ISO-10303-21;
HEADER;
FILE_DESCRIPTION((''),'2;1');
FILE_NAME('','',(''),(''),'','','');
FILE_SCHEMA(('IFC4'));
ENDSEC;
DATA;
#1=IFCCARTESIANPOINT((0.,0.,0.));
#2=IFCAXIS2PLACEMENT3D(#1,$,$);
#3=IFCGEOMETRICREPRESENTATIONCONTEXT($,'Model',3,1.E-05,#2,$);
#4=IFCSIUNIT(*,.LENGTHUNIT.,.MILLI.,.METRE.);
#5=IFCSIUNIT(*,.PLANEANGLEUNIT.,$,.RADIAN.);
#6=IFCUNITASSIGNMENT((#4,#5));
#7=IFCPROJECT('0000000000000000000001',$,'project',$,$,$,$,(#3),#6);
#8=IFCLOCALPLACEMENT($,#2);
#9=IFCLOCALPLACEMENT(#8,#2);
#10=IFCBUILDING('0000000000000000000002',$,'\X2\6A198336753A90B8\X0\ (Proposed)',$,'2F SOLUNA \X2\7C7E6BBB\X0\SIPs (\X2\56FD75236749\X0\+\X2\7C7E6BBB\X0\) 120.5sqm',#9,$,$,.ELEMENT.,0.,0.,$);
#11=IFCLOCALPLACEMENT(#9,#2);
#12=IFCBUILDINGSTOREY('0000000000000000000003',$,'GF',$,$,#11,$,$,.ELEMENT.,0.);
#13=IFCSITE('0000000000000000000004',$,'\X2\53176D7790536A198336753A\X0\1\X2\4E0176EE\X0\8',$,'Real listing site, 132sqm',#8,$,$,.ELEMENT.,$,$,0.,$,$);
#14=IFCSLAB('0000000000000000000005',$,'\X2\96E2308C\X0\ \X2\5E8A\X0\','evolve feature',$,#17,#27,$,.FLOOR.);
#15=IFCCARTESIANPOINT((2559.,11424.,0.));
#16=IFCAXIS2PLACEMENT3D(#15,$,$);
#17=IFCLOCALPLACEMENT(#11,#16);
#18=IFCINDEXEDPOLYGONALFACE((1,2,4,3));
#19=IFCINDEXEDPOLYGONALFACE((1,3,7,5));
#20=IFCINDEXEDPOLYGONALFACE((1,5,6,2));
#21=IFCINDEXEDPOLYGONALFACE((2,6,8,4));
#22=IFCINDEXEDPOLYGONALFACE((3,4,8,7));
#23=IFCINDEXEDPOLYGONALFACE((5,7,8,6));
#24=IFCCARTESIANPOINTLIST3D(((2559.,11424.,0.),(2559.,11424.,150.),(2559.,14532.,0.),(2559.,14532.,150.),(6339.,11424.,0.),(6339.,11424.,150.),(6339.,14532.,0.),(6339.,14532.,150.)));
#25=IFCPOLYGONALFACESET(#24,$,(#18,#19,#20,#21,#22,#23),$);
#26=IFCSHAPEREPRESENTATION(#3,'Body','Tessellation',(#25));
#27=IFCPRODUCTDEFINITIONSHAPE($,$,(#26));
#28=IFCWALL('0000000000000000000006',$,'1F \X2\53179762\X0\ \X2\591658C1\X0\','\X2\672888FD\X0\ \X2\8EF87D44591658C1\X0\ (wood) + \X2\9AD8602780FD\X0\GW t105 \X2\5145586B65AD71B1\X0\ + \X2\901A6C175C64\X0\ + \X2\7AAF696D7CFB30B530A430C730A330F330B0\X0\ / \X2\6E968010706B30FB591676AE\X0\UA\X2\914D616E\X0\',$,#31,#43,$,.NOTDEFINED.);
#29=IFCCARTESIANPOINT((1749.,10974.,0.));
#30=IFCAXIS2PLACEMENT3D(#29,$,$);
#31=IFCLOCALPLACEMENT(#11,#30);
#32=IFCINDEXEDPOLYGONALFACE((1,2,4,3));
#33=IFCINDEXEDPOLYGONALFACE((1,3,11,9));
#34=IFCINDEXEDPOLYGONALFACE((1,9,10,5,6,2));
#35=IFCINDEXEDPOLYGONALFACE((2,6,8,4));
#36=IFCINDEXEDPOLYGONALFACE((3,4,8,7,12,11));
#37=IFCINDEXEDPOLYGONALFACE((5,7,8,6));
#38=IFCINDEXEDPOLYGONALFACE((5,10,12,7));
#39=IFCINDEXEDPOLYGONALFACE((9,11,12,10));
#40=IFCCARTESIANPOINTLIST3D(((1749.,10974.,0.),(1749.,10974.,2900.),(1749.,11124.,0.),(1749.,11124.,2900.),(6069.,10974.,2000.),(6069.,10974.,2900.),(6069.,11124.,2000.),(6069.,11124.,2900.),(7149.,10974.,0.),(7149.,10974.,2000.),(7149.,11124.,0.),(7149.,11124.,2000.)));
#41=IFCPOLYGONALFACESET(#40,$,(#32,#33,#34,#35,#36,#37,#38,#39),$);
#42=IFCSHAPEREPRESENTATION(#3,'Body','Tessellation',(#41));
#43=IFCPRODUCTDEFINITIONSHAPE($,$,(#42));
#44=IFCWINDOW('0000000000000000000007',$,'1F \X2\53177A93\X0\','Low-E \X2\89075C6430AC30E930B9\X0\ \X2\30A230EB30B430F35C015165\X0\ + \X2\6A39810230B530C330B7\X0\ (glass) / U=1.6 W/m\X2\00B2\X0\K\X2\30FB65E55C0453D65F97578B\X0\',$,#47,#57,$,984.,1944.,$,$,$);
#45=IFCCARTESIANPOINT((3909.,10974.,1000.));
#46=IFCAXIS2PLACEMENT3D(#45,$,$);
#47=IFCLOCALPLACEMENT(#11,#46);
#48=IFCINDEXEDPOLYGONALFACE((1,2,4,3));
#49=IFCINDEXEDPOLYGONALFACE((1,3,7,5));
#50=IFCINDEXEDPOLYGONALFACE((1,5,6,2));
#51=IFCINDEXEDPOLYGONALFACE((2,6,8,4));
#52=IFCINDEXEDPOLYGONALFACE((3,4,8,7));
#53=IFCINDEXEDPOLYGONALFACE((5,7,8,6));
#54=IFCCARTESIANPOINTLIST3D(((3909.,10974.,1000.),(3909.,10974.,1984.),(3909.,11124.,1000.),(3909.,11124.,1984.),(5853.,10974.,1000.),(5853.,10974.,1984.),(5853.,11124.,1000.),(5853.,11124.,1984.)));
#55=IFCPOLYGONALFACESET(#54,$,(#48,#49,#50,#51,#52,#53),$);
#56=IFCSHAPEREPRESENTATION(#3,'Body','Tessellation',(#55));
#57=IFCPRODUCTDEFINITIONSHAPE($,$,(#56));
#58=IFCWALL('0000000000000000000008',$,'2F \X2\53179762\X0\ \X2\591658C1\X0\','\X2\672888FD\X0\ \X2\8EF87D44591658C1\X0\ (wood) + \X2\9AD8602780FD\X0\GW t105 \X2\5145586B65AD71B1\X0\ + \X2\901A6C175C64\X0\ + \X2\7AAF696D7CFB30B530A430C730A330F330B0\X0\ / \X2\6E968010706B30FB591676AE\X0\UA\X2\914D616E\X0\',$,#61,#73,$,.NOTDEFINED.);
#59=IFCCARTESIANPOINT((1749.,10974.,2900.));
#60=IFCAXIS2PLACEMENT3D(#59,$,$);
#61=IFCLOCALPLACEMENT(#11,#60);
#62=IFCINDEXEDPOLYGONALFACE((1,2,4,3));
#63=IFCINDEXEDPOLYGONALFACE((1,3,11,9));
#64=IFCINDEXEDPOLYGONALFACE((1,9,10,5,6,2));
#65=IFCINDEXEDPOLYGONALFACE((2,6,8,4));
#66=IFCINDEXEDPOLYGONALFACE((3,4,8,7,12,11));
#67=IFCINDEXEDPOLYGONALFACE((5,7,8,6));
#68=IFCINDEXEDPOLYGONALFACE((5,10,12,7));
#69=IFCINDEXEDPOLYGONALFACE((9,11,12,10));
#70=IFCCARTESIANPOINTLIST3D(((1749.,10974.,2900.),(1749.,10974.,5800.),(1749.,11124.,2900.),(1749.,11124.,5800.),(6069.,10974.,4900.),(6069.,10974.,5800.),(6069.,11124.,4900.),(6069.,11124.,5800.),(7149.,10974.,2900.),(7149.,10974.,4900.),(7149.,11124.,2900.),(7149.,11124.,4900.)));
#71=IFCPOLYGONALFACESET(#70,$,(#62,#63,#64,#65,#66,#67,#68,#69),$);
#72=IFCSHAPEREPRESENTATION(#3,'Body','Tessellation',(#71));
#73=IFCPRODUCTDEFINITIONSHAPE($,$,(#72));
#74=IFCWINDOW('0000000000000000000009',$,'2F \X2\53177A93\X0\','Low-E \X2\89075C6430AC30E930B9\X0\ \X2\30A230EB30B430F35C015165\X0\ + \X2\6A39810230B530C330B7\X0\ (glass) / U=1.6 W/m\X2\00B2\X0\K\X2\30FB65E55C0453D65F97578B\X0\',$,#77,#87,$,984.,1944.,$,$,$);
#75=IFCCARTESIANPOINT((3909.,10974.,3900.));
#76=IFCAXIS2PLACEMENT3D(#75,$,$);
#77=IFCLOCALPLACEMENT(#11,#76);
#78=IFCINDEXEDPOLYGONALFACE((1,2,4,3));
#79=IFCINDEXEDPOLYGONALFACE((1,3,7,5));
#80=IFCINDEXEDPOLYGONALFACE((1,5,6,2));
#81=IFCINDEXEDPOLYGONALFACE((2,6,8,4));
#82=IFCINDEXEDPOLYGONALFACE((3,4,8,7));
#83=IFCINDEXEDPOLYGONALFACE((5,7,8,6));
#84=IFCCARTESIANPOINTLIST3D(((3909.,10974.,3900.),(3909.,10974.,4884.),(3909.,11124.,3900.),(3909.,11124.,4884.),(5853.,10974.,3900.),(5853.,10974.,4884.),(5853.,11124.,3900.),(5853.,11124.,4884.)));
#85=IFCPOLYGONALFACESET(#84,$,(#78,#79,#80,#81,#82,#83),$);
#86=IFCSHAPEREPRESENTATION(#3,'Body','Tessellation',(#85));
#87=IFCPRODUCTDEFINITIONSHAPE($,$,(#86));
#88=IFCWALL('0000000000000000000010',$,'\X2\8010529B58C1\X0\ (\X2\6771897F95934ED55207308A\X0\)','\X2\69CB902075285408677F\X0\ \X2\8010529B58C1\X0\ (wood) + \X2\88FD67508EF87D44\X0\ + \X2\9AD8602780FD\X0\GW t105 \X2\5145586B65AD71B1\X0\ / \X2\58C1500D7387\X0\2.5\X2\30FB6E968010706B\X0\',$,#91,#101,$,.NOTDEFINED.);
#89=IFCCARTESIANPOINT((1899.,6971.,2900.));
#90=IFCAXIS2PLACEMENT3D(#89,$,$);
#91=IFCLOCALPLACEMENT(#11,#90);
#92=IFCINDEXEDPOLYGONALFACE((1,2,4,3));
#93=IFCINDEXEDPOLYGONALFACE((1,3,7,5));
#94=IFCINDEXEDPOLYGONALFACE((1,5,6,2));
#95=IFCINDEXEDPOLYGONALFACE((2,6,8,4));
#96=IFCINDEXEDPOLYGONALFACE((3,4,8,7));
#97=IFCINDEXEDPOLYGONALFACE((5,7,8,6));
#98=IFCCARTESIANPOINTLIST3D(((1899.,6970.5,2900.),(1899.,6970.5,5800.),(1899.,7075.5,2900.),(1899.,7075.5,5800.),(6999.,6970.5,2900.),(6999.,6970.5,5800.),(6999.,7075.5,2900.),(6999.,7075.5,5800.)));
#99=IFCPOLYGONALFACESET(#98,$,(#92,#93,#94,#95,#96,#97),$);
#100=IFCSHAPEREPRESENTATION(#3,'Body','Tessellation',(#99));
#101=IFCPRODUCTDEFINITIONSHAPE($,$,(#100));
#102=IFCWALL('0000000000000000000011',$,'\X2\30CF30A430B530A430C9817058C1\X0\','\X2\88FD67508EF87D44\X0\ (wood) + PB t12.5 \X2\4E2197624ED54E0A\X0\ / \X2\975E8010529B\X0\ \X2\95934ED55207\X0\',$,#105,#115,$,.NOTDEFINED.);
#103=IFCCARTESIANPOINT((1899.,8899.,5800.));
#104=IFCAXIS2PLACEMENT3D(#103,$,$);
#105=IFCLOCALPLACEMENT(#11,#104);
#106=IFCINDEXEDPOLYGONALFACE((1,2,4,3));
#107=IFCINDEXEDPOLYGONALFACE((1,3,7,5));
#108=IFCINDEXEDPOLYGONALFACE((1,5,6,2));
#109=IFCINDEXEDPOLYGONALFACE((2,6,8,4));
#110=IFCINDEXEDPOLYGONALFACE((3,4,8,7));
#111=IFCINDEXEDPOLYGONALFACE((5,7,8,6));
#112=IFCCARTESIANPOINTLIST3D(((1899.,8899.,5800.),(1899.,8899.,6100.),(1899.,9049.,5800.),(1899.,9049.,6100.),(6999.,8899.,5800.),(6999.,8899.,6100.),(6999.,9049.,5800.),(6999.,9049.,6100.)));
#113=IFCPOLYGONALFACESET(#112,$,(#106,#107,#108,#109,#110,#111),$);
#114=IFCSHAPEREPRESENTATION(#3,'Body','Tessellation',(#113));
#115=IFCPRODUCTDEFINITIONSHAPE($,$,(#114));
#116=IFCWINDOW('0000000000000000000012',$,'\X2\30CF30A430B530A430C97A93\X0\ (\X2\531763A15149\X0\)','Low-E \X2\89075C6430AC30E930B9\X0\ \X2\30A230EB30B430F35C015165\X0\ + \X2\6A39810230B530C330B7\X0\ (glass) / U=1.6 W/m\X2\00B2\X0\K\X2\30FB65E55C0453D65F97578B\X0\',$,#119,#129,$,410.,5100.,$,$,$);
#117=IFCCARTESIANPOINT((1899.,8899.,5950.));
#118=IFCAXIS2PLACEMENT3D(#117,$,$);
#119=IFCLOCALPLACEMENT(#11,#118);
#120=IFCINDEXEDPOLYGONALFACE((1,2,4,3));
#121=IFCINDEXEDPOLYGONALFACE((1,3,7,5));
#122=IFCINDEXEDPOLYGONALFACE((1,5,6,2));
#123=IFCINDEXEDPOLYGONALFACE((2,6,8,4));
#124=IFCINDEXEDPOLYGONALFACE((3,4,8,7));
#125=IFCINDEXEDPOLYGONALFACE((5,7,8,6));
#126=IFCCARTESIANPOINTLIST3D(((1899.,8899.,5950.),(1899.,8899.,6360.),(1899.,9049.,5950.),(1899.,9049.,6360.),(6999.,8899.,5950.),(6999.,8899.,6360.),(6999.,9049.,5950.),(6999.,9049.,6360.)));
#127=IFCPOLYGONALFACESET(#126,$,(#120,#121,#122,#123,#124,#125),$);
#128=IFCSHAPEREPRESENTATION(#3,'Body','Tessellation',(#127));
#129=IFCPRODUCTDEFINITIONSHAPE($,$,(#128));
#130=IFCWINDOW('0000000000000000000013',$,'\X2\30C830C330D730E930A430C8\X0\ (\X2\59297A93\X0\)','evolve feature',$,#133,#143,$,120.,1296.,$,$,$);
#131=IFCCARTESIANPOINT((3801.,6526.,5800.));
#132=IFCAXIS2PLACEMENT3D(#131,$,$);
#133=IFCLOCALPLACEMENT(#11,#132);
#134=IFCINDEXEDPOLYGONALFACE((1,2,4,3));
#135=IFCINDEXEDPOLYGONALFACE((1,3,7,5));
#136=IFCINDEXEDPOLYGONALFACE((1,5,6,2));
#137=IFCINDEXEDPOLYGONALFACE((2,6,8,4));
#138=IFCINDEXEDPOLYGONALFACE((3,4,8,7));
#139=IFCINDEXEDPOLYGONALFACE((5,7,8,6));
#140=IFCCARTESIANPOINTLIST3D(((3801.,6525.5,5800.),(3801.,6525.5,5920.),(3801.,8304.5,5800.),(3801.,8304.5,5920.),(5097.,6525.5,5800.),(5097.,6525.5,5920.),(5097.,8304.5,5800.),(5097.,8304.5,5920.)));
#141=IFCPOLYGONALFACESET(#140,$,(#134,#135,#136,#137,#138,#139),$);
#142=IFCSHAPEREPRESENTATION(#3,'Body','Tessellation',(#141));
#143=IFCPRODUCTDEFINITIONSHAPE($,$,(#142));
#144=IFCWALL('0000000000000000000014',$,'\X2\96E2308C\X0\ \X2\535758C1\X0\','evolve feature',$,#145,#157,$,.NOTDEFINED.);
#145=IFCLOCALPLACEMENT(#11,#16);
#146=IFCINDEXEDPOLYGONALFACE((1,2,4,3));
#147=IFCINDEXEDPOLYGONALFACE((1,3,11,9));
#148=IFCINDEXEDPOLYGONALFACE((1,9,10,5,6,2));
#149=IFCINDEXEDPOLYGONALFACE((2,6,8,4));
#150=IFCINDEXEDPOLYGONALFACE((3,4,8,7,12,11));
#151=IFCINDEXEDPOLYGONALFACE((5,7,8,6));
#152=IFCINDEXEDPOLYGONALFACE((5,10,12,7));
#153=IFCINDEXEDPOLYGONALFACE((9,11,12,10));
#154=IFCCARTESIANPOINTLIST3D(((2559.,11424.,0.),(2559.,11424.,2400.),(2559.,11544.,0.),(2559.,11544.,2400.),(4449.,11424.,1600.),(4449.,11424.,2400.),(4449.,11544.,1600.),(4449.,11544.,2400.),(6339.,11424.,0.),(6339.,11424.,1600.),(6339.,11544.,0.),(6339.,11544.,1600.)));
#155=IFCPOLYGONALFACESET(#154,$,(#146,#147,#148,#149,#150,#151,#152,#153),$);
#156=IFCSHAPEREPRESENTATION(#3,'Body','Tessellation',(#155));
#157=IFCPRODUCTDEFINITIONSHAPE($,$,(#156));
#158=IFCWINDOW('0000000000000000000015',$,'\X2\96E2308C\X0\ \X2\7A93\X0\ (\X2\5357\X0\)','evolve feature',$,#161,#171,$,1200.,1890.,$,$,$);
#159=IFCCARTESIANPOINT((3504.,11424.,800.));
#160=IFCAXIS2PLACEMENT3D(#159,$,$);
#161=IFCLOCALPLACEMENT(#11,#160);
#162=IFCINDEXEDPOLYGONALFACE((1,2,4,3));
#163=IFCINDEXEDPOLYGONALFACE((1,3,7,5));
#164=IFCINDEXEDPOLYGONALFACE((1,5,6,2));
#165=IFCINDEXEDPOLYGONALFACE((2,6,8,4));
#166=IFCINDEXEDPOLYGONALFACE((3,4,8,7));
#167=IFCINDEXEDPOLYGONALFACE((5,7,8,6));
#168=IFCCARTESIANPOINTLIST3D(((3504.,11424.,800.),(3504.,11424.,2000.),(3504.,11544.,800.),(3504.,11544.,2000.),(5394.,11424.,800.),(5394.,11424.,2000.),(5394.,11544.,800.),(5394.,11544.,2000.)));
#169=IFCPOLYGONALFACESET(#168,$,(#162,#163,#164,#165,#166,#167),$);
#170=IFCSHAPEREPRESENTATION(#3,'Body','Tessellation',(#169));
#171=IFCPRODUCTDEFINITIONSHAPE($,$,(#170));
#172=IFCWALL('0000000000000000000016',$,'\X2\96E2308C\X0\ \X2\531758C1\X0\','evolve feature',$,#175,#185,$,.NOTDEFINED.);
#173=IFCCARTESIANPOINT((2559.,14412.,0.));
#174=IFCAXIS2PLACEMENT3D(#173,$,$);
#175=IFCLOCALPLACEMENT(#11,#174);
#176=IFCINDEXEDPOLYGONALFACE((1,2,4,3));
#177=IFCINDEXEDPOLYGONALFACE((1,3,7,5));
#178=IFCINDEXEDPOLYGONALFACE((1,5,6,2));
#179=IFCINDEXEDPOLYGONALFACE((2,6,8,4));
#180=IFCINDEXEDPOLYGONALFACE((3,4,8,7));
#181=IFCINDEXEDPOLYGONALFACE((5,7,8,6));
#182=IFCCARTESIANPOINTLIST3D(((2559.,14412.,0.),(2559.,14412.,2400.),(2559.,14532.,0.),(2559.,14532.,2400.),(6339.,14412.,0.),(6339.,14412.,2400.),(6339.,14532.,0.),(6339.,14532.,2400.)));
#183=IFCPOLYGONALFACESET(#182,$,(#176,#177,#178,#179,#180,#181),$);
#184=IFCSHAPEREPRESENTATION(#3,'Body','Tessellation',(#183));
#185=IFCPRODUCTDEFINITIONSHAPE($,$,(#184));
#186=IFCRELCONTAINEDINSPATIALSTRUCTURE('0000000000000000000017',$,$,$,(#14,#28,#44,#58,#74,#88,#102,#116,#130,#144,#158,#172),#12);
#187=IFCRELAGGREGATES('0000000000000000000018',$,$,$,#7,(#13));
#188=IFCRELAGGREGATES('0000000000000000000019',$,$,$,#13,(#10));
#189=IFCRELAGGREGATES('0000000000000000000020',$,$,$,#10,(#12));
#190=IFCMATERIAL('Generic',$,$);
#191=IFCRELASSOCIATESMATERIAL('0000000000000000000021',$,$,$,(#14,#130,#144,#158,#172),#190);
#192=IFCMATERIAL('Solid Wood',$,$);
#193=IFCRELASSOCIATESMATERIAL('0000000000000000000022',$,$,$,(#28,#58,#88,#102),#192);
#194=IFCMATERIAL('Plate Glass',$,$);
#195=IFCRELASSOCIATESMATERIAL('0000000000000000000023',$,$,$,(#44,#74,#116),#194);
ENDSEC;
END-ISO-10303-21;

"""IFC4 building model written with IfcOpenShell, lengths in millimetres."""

from ifc_helpers import new_model, si_unit, frame, frame_2d, origin, place, context, project, spatial, rectangle, extrude, material, element, fill, save


model = new_model("IFC4")

# Units and contexts
model_context = context("Model", 3, precision=1e-05, world=origin())
ifc_project = project(units=[si_unit("LENGTHUNIT", "METRE", prefix="MILLI"), si_unit("PLANEANGLEUNIT", "RADIAN")], contexts=[model_context])

# Site, building, storey
site_placement = place(None, origin())
site = spatial("IfcSite", under=ifc_project, at=site_placement, Name="北海道標茶町1丁目8", ObjectType="Real listing site, 132sqm", CompositionType="ELEMENT", RefElevation=0.0)
building_placement = place(site_placement, origin())
building = spatial("IfcBuilding", under=site, at=building_placement, Name="標茶町邸 (Proposed)", ObjectType="2F SOLUNA 籾殻SIPs (国産杉+籾殻) 120.5sqm", CompositionType="ELEMENT", ElevationOfRefHeight=0.0, ElevationOfTerrain=0.0)
storey_placement = place(building_placement, origin())
storey = spatial("IfcBuildingStorey", under=building, at=storey_placement, Name="GF", CompositionType="ELEMENT", Elevation=0.0)

# Slab
ifc_material_1 = material(Name="Generic")
slab_placement = place(storey_placement, frame((2559.0, 11424.0, 0.0)))
element("IfcSlab", 1, at=slab_placement, inside=storey, material=ifc_material_1, Name="離れ 床", Description="evolve feature", PredefinedType="FLOOR", context=model_context, shape_type="SweptSolid", body=[
    extrude(rectangle(XDim=3780.0, YDim=3108.0, at=frame_2d((1890.0, 1554.0))), frame((2559.0, 11424.0, 0.0)), (0.0, 0.0, 1.0), 150.0),
])

# Wall, opening, window
ifc_material_2 = material(Name="Solid Wood")
wall_1_placement = place(storey_placement, frame((1749.0, 10974.0, 0.0)))
wall_1 = element("IfcWall", 2, at=wall_1_placement, inside=storey, material=ifc_material_2, Name="1F 北面 外壁", Description="木製 軸組外壁 (wood) + 高性能GW t105 充填断熱 + 通気層 + 窯業系サイディング / 準耐火・外皮UA配慮", PredefinedType="NOTDEFINED", context=model_context, shape_type="SweptSolid", body=[
    extrude(rectangle(XDim=5400.0, YDim=150.0, at=frame_2d((2700.0, 75.0))), frame((1749.0, 10974.0, 0.0)), (0.0, 0.0, 1.0), 2900.0),
])
opening_1_placement = place(storey_placement, frame((3909.0, 10974.0, 1000.0)))
opening_1 = element("IfcOpeningElement", 3, at=opening_1_placement, cuts=wall_1, PredefinedType="NOTDEFINED", context=model_context, shape_type="SweptSolid", body=[
    extrude(rectangle(XDim=1944.0, YDim=150.0, at=frame_2d((972.0, 75.0))), frame((3909.0, 10974.0, 1000.0)), (0.0, 0.0, 1.0), 984.0),
])
ifc_material_3 = material(Name="Plate Glass")
window_1_placement = place(storey_placement, frame((3909.0, 10974.0, 1000.0)))
window_1 = element("IfcWindow", 4, at=window_1_placement, inside=storey, material=ifc_material_3, Name="1F 北窓", Description="Low-E 複層ガラス アルゴン封入 + 樹脂サッシ (glass) / U=1.6 W/m²K・日射取得型", OverallHeight=984.0, OverallWidth=1944.0, context=model_context, shape_type="SweptSolid", body=[
    extrude(rectangle(XDim=1944.0, YDim=150.0, at=frame_2d((972.0, 75.0))), frame((3909.0, 10974.0, 1000.0)), (0.0, 0.0, 1.0), 984.0),
])
fill(opening_1, window_1)

# Wall, opening, window
wall_2_placement = place(storey_placement, frame((1749.0, 10974.0, 2900.0)))
wall_2 = element("IfcWall", 5, at=wall_2_placement, inside=storey, material=ifc_material_2, Name="2F 北面 外壁", Description="木製 軸組外壁 (wood) + 高性能GW t105 充填断熱 + 通気層 + 窯業系サイディング / 準耐火・外皮UA配慮", PredefinedType="NOTDEFINED", context=model_context, shape_type="SweptSolid", body=[
    extrude(rectangle(XDim=5400.0, YDim=150.0, at=frame_2d((2700.0, 75.0))), frame((1749.0, 10974.0, 2900.0)), (0.0, 0.0, 1.0), 2900.0),
])
opening_2_placement = place(storey_placement, frame((3909.0, 10974.0, 3900.0)))
opening_2 = element("IfcOpeningElement", 6, at=opening_2_placement, cuts=wall_2, PredefinedType="NOTDEFINED", context=model_context, shape_type="SweptSolid", body=[
    extrude(rectangle(XDim=1944.0, YDim=150.0, at=frame_2d((972.0, 75.0))), frame((3909.0, 10974.0, 3900.0)), (0.0, 0.0, 1.0), 984.0),
])
window_2_placement = place(storey_placement, frame((3909.0, 10974.0, 3900.0)))
window_2 = element("IfcWindow", 7, at=window_2_placement, inside=storey, material=ifc_material_3, Name="2F 北窓", Description="Low-E 複層ガラス アルゴン封入 + 樹脂サッシ (glass) / U=1.6 W/m²K・日射取得型", OverallHeight=984.0, OverallWidth=1944.0, context=model_context, shape_type="SweptSolid", body=[
    extrude(rectangle(XDim=1944.0, YDim=150.0, at=frame_2d((972.0, 75.0))), frame((3909.0, 10974.0, 3900.0)), (0.0, 0.0, 1.0), 984.0),
])
fill(opening_2, window_2)

# Wall
wall_3_placement = place(storey_placement, frame((1899.0, 6971.0, 2900.0)))
element("IfcWall", 8, at=wall_3_placement, inside=storey, material=ifc_material_2, Name="耐力壁 (東西間仕切り)", Description="構造用合板 耐力壁 (wood) + 製材軸組 + 高性能GW t105 充填断熱 / 壁倍率2.5・準耐火", PredefinedType="NOTDEFINED", context=model_context, shape_type="SweptSolid", body=[
    extrude(rectangle(XDim=5100.0, YDim=105.0, at=frame_2d((2550.0, 52.0))), frame((1899.0, 6971.0, 2900.0)), (0.0, 0.0, 1.0), 2900.0),
])

# Wall, opening, window
wall_4_placement = place(storey_placement, frame((1899.0, 8899.0, 5800.0)))
wall_4 = element("IfcWall", 9, at=wall_4_placement, inside=storey, material=ifc_material_2, Name="ハイサイド腰壁", Description="製材軸組 (wood) + PB t12.5 両面仕上 / 非耐力 間仕切", PredefinedType="NOTDEFINED", context=model_context, shape_type="SweptSolid", body=[
    extrude(rectangle(XDim=5100.0, YDim=150.0, at=frame_2d((2550.0, 75.0))), frame((1899.0, 8899.0, 5800.0)), (0.0, 0.0, 1.0), 700.0),
])
opening_3_placement = place(storey_placement, frame((1899.0, 8899.0, 5950.0)))
opening_3 = element("IfcOpeningElement", 10, at=opening_3_placement, cuts=wall_4, PredefinedType="NOTDEFINED", context=model_context, shape_type="SweptSolid", body=[
    extrude(rectangle(XDim=5100.0, YDim=150.0, at=frame_2d((2550.0, 75.0))), frame((1899.0, 8899.0, 5950.0)), (0.0, 0.0, 1.0), 410.0),
])
window_3_placement = place(storey_placement, frame((1899.0, 8899.0, 5950.0)))
window_3 = element("IfcWindow", 11, at=window_3_placement, inside=storey, material=ifc_material_3, Name="ハイサイド窓 (北採光)", Description="Low-E 複層ガラス アルゴン封入 + 樹脂サッシ (glass) / U=1.6 W/m²K・日射取得型", OverallHeight=410.0, OverallWidth=5100.0, context=model_context, shape_type="SweptSolid", body=[
    extrude(rectangle(XDim=5100.0, YDim=150.0, at=frame_2d((2550.0, 75.0))), frame((1899.0, 8899.0, 5950.0)), (0.0, 0.0, 1.0), 410.0),
])
fill(opening_3, window_3)

# Window
window_4_placement = place(storey_placement, frame((3801.0, 6526.0, 5800.0)))
element("IfcWindow", 12, at=window_4_placement, inside=storey, material=ifc_material_1, Name="トップライト (天窓)", Description="evolve feature", OverallHeight=120.0, OverallWidth=1296.0, context=model_context, shape_type="SweptSolid", body=[
    extrude(rectangle(XDim=1296.0, YDim=1779.0, at=frame_2d((648.0, 889.0))), frame((3801.0, 6526.0, 5800.0)), (0.0, 0.0, 1.0), 120.0),
])

# Wall, opening, window
wall_5_placement = place(storey_placement, frame((2559.0, 11424.0, 0.0)))
wall_5 = element("IfcWall", 13, at=wall_5_placement, inside=storey, material=ifc_material_1, Name="離れ 南壁", Description="evolve feature", PredefinedType="NOTDEFINED", context=model_context, shape_type="SweptSolid", body=[
    extrude(rectangle(XDim=3780.0, YDim=120.0, at=frame_2d((1890.0, 60.0))), frame((2559.0, 11424.0, 0.0)), (0.0, 0.0, 1.0), 2400.0),
])
opening_4_placement = place(storey_placement, frame((3504.0, 11424.0, 800.0)))
opening_4 = element("IfcOpeningElement", 14, at=opening_4_placement, cuts=wall_5, PredefinedType="NOTDEFINED", context=model_context, shape_type="SweptSolid", body=[
    extrude(rectangle(XDim=1890.0, YDim=120.0, at=frame_2d((945.0, 60.0))), frame((3504.0, 11424.0, 800.0)), (0.0, 0.0, 1.0), 1200.0),
])
window_5_placement = place(storey_placement, frame((3504.0, 11424.0, 800.0)))
window_5 = element("IfcWindow", 15, at=window_5_placement, inside=storey, material=ifc_material_1, Name="離れ 窓 (南)", Description="evolve feature", OverallHeight=1200.0, OverallWidth=1890.0, context=model_context, shape_type="SweptSolid", body=[
    extrude(rectangle(XDim=1890.0, YDim=120.0, at=frame_2d((945.0, 60.0))), frame((3504.0, 11424.0, 800.0)), (0.0, 0.0, 1.0), 1200.0),
])
fill(opening_4, window_5)

# Wall
wall_6_placement = place(storey_placement, frame((2559.0, 14412.0, 0.0)))
element("IfcWall", 16, at=wall_6_placement, inside=storey, material=ifc_material_1, Name="離れ 北壁", Description="evolve feature", PredefinedType="NOTDEFINED", context=model_context, shape_type="SweptSolid", body=[
    extrude(rectangle(XDim=3780.0, YDim=120.0, at=frame_2d((1890.0, 60.0))), frame((2559.0, 14412.0, 0.0)), (0.0, 0.0, 1.0), 2400.0),
])

save(model, "model.ifc")
